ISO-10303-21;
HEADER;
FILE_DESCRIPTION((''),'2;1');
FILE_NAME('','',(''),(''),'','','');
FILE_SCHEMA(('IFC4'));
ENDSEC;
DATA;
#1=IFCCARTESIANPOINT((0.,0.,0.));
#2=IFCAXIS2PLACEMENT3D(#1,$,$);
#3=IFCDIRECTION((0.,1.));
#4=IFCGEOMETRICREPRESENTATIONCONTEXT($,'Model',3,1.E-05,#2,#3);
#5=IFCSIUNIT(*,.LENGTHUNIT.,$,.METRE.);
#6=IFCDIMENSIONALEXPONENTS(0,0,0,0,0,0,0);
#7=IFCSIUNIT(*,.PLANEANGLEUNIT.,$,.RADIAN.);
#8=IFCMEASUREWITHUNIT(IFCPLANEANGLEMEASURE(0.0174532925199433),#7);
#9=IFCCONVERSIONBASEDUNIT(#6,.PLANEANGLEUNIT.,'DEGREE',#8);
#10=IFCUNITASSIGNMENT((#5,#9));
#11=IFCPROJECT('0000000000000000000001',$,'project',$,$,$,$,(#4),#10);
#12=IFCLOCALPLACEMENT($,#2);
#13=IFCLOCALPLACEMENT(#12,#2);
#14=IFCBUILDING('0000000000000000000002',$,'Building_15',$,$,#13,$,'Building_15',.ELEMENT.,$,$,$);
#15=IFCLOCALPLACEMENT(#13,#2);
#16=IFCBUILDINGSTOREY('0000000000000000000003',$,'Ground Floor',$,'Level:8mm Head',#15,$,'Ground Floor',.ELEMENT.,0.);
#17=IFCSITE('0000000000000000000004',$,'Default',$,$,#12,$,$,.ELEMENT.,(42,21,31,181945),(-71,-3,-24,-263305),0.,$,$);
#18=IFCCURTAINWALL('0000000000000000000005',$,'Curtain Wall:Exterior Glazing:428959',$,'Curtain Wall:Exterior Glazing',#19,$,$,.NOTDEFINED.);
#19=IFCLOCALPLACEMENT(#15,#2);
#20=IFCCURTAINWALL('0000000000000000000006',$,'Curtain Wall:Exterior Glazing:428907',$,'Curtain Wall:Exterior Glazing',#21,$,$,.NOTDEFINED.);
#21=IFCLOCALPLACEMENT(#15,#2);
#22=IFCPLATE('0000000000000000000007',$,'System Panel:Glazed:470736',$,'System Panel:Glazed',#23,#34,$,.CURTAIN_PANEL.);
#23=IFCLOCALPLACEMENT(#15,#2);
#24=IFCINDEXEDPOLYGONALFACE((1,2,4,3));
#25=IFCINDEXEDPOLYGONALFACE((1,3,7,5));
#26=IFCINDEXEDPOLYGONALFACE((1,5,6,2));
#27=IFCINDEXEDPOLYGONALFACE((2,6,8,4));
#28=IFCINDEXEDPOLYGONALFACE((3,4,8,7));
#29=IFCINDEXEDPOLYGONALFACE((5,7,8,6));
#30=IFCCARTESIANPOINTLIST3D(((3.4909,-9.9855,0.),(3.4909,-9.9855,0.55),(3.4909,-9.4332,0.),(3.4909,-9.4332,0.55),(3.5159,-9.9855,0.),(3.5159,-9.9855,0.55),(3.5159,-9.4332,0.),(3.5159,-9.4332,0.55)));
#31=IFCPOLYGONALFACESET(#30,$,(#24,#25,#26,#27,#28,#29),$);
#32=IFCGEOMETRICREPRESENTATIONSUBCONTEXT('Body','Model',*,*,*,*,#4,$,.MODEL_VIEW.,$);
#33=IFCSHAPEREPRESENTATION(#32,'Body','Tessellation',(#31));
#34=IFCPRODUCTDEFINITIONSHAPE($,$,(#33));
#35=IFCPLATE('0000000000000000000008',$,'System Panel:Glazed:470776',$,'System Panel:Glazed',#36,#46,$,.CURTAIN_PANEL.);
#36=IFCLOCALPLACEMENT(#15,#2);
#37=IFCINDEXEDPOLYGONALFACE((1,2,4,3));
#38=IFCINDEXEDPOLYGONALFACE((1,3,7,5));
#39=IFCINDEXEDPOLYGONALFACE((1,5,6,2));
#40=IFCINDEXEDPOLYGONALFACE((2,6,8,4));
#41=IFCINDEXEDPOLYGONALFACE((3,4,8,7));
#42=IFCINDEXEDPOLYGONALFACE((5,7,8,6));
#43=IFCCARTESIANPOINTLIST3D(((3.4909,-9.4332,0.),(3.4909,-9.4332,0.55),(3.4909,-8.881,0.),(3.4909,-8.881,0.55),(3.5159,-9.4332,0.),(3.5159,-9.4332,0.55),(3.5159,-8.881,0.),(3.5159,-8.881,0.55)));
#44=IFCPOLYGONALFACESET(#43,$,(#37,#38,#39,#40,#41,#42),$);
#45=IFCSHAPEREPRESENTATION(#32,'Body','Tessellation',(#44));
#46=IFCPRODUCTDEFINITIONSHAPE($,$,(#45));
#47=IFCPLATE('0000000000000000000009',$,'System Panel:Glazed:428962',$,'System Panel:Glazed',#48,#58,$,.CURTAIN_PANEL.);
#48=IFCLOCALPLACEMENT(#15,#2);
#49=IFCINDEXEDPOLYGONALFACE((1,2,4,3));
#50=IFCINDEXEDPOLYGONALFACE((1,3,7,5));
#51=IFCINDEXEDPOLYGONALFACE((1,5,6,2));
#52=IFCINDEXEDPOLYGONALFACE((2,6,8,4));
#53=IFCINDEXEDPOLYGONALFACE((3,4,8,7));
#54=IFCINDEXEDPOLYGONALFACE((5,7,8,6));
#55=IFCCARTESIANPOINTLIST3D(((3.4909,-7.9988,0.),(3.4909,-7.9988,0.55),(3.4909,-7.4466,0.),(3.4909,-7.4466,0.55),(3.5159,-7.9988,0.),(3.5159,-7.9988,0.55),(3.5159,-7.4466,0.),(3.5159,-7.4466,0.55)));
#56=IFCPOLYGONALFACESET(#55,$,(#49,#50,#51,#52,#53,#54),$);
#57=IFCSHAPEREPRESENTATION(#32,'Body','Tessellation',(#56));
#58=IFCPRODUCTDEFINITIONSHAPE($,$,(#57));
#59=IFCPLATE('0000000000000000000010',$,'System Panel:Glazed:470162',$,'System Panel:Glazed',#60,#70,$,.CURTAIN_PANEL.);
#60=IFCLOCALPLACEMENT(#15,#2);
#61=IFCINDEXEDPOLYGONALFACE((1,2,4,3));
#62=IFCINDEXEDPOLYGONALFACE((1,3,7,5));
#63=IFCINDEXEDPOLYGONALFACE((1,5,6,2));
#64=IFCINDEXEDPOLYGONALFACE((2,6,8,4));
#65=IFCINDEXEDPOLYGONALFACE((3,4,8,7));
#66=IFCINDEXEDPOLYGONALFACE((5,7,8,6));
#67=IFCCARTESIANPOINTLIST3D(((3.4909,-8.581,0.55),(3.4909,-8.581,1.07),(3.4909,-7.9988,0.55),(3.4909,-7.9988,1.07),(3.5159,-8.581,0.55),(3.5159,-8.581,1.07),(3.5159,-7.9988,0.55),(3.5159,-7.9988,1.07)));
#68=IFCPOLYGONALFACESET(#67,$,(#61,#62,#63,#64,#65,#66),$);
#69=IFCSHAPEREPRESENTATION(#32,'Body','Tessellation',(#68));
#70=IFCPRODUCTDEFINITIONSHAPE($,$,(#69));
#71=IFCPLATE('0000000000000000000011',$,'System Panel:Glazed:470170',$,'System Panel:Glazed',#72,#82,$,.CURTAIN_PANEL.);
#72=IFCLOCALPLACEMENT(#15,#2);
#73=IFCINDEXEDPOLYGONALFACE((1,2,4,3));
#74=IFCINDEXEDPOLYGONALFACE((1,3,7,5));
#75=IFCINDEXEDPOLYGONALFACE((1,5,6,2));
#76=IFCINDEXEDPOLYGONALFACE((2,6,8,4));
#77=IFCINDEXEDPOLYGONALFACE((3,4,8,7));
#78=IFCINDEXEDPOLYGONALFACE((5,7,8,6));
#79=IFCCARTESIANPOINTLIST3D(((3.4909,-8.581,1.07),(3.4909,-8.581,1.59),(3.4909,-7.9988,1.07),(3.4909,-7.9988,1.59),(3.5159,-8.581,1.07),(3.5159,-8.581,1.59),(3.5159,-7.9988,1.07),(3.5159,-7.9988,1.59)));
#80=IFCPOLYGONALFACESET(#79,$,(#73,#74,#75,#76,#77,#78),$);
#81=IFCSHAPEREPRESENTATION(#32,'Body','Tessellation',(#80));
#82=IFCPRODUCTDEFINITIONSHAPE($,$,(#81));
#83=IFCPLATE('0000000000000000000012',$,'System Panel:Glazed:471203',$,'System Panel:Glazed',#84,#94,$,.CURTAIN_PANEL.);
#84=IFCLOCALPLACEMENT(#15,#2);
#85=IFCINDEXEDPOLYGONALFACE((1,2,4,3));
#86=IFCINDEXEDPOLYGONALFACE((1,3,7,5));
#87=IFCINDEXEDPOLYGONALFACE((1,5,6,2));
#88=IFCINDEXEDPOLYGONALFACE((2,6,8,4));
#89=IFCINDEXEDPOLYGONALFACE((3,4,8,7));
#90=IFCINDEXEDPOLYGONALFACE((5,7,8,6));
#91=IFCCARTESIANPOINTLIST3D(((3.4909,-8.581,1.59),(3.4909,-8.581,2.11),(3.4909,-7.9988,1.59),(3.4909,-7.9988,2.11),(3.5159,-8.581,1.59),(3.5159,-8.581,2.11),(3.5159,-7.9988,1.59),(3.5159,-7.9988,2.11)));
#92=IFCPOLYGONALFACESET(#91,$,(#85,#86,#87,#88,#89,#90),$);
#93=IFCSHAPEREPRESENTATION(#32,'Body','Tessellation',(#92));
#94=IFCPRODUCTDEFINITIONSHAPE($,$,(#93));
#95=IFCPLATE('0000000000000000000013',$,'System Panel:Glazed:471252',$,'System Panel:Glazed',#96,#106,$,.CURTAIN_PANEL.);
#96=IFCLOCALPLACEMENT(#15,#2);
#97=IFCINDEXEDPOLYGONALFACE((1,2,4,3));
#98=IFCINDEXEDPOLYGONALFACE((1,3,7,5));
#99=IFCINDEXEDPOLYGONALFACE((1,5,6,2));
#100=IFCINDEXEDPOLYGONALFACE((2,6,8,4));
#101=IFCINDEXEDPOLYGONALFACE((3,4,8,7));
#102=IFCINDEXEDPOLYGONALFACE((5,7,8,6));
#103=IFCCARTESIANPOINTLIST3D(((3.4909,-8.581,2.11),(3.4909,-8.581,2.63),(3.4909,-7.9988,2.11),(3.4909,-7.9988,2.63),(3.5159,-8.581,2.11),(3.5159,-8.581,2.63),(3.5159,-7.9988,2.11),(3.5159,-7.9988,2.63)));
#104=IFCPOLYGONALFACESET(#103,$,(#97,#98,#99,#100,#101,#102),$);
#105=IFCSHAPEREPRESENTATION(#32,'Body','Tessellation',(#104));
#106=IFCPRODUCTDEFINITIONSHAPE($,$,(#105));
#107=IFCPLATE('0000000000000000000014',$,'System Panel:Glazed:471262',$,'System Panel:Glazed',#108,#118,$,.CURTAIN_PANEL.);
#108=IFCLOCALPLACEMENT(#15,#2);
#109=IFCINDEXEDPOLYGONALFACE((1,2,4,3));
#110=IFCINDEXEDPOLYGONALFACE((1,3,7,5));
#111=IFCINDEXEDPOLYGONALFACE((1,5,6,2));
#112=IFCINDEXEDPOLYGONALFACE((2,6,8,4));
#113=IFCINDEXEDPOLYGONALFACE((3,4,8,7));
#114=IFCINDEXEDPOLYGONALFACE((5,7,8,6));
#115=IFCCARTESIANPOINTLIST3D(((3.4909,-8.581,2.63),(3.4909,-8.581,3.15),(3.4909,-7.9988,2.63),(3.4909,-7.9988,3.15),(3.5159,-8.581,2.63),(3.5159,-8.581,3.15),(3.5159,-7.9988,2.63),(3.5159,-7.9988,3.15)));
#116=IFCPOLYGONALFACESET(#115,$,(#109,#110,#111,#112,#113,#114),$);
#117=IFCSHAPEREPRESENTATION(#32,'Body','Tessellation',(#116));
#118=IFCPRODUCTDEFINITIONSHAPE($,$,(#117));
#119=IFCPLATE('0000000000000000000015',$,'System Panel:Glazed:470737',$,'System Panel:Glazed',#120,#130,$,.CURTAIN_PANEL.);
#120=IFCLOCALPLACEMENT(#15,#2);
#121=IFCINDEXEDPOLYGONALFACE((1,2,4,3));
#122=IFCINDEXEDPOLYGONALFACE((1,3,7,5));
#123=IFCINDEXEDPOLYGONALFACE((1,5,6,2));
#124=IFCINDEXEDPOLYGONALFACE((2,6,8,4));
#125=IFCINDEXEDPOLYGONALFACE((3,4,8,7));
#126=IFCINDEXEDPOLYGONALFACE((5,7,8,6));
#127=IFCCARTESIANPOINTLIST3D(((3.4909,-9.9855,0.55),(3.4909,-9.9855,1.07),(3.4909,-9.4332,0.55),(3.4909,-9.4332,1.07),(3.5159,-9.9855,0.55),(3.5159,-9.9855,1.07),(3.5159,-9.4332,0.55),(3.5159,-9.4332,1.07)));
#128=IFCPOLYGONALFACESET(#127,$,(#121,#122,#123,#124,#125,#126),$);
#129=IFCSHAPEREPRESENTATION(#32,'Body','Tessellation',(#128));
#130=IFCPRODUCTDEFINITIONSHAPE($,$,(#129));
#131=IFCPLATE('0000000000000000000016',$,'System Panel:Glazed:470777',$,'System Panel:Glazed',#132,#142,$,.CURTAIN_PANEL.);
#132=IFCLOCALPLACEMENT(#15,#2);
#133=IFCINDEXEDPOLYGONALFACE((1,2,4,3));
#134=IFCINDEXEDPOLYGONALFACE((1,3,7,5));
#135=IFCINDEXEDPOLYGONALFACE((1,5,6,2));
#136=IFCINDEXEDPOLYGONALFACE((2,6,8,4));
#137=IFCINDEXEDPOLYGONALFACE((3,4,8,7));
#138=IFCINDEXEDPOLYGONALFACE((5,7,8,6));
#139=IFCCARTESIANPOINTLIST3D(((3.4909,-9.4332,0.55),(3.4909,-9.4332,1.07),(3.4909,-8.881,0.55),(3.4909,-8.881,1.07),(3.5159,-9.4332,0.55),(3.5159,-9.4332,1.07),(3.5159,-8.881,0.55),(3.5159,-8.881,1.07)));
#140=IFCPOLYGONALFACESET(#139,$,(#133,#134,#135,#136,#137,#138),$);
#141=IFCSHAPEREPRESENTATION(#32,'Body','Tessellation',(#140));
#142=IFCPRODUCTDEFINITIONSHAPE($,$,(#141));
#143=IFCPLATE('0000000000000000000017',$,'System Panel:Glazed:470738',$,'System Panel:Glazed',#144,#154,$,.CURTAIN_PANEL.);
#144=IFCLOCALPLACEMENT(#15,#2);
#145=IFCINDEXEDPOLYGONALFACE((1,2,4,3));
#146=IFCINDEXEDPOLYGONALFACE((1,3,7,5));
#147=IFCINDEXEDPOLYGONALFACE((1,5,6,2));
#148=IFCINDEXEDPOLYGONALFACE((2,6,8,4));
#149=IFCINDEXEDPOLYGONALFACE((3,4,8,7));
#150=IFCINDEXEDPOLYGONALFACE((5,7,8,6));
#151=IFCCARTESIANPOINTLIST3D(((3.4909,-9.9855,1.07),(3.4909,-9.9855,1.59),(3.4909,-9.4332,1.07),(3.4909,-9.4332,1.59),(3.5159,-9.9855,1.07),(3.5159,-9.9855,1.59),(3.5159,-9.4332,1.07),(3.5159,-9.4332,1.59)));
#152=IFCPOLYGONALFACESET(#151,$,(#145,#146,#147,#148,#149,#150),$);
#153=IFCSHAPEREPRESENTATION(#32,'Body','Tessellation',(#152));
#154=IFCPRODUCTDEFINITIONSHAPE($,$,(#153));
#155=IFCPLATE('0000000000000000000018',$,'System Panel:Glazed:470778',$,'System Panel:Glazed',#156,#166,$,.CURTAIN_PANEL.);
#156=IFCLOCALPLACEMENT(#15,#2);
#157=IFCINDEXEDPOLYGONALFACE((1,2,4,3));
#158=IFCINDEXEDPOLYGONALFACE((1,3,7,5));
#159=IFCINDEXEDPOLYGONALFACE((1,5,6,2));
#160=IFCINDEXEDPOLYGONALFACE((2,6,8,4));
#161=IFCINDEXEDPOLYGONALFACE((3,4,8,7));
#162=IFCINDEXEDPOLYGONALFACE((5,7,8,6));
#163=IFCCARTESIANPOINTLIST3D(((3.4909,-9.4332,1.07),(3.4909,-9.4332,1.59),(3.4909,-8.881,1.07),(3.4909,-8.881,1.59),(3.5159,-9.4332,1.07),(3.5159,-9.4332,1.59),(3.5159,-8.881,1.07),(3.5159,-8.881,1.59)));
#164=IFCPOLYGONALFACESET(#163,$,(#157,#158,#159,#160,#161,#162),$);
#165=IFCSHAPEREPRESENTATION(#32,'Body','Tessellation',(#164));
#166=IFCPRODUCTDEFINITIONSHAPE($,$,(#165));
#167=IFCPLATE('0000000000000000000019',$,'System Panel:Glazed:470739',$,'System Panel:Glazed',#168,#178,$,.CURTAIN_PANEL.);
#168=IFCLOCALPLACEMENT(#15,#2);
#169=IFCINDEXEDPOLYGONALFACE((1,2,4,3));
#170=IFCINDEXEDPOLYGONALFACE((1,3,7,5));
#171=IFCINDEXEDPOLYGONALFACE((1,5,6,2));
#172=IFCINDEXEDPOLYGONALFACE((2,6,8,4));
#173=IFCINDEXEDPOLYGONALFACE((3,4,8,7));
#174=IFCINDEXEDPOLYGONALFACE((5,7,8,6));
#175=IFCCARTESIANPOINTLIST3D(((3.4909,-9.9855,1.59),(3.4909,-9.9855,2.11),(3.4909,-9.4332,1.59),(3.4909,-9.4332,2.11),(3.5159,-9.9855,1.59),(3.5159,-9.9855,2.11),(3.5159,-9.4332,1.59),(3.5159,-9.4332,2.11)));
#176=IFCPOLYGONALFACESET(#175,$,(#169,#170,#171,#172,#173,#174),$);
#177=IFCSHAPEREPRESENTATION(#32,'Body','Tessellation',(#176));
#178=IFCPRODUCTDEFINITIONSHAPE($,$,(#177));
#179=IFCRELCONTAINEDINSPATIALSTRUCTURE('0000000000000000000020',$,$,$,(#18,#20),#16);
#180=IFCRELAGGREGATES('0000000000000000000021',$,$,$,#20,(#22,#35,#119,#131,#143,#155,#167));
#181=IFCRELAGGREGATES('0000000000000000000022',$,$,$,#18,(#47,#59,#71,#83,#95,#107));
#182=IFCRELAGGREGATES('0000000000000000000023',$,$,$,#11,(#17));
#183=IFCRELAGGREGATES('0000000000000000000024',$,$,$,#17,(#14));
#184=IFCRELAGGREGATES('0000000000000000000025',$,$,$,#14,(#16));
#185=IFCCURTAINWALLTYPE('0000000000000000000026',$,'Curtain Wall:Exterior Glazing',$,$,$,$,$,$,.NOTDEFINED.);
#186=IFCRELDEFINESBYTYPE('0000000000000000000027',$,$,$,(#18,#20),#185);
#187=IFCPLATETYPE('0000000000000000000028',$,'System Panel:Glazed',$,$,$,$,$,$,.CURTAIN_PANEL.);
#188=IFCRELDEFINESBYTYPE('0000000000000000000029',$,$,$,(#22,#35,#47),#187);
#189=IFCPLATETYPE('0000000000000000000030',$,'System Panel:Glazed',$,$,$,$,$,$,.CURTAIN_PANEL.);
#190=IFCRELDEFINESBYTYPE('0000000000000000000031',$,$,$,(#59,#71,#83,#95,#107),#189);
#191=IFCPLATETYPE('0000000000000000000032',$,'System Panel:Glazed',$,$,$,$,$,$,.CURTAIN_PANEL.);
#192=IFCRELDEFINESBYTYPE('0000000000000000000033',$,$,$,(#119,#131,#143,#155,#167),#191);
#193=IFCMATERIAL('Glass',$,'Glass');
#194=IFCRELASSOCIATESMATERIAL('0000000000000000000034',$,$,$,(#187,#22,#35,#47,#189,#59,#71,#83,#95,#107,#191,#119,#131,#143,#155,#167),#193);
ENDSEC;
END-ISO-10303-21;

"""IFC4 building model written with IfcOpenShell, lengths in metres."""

from ifc_helpers import new_model, entity, si_unit, converted_unit, direction, frame, origin, place, context, subcontext, project, spatial, indexed_curve, outline, extrude, source, transform, mapped, material, type_object, type_shapes, element, aggregate, save


model = new_model("IFC4")

# Units and contexts
model_context = context("Model", 3, precision=1e-05, world=origin(), true_north=direction((0.0, 1.0)))
body_context = subcontext(model_context, "Body", "Model", "MODEL_VIEW")
ifc_project = project(units=[si_unit("LENGTHUNIT", "METRE"), converted_unit("PLANEANGLEUNIT", "DEGREE", entity("IfcPlaneAngleMeasure", 0.0174532925199433), si_unit("PLANEANGLEUNIT", "RADIAN"), dimensions=[0, 0, 0, 0, 0, 0, 0])], contexts=[model_context])

# Site, building, storey
site_placement = place(None, origin())
site = spatial("IfcSite", under=ifc_project, at=site_placement, Name="Default", CompositionType="ELEMENT", RefLatitude=(42, 21, 31, 181945), RefLongitude=(-71, -3, -24, -263305), RefElevation=0.0)
building_placement = place(site_placement, origin())
building = spatial("IfcBuilding", under=site, at=building_placement, Name="Building_15", LongName="Building_15", CompositionType="ELEMENT")
storey_placement = place(building_placement, origin())
storey = spatial("IfcBuildingStorey", under=building, at=storey_placement, Name="Ground Floor", ObjectType="Level:8mm Head", LongName="Ground Floor", CompositionType="ELEMENT", Elevation=0.0)

# Curtain wall
curtain_wall_type = type_object("IfcCurtainWallType", Name="Curtain Wall:Exterior Glazing", PredefinedType="NOTDEFINED")
curtain_wall_1_placement = place(storey_placement, origin())
curtain_wall_1 = element("IfcCurtainWall", 1, at=curtain_wall_1_placement, inside=storey, type_object=curtain_wall_type, Name="Curtain Wall:Exterior Glazing:428959", ObjectType="Curtain Wall:Exterior Glazing", PredefinedType="NOTDEFINED")

# Curtain wall
curtain_wall_2_placement = place(storey_placement, origin())
curtain_wall_2 = element("IfcCurtainWall", 2, at=curtain_wall_2_placement, inside=storey, type_object=curtain_wall_type, Name="Curtain Wall:Exterior Glazing:428907", ObjectType="Curtain Wall:Exterior Glazing", PredefinedType="NOTDEFINED")

# Plates
ifc_material_1 = material(Name="Glass", Category="Glass")
plate_type_1 = type_object("IfcPlateType", Name="System Panel:Glazed", PredefinedType="CURTAIN_PANEL", material=ifc_material_1)
shared_shape_1 = source(origin(), body_context, "Body", "SweptSolid", [
    extrude(outline(indexed_curve([(-0.0125, -0.2761), (0.0125, -0.2761), (0.0125, 0.2761), (-0.0125, 0.2761), (-0.0125, -0.2761)], self_intersect=False)), frame((0.0, 0.037, 0.0), z_axis=(0.0, 0.0, 1.0), x_axis=(0.0, 1.0, 0.0)), (0.0, 0.0, 1.0), 0.55),
])
type_shapes(plate_type_1, [shared_shape_1])
plate_1_placement = place(curtain_wall_2_placement, frame((3.5404, -9.7093, 0.0), z_axis=(0.0, 0.0, 1.0), x_axis=(0.0, 1.0, 0.0)))
plate_1 = element("IfcPlate", 3, at=plate_1_placement, type_object=plate_type_1, material=ifc_material_1, Name="System Panel:Glazed:470736", ObjectType="System Panel:Glazed", PredefinedType="CURTAIN_PANEL", context=body_context, shape_type="MappedRepresentation", body=[
    mapped(shared_shape_1, transform((0.0, 0.0, 0.0), scale=1.0)),
])
plate_2_placement = place(curtain_wall_2_placement, frame((3.5404, -9.1571, 0.0), z_axis=(0.0, 0.0, 1.0), x_axis=(0.0, 1.0, 0.0)))
plate_2 = element("IfcPlate", 4, at=plate_2_placement, type_object=plate_type_1, material=ifc_material_1, Name="System Panel:Glazed:470776", ObjectType="System Panel:Glazed", PredefinedType="CURTAIN_PANEL", context=body_context, shape_type="MappedRepresentation", body=[
    mapped(shared_shape_1, transform((0.0, 0.0, 0.0), scale=1.0)),
])
plate_3_placement = place(curtain_wall_1_placement, frame((3.5404, -7.7227, 0.0), z_axis=(0.0, 0.0, 1.0), x_axis=(0.0, 1.0, 0.0)))
plate_3 = element("IfcPlate", 5, at=plate_3_placement, type_object=plate_type_1, material=ifc_material_1, Name="System Panel:Glazed:428962", ObjectType="System Panel:Glazed", PredefinedType="CURTAIN_PANEL", context=body_context, shape_type="MappedRepresentation", body=[
    mapped(shared_shape_1, transform((0.0, 0.0, 0.0), scale=1.0)),
])
plate_type_2 = type_object("IfcPlateType", Name="System Panel:Glazed", PredefinedType="CURTAIN_PANEL", material=ifc_material_1)
shared_shape_2 = source(origin(), body_context, "Body", "SweptSolid", [
    extrude(outline(indexed_curve([(-0.0125, -0.2911), (0.0125, -0.2911), (0.0125, 0.2911), (-0.0125, 0.2911), (-0.0125, -0.2911)], self_intersect=False)), frame((0.0, 0.037, 0.0), z_axis=(0.0, 0.0, 1.0), x_axis=(0.0, 1.0, 0.0)), (0.0, 0.0, 1.0), 0.52),
])
type_shapes(plate_type_2, [shared_shape_2])
plate_4_placement = place(curtain_wall_1_placement, frame((3.5404, -8.2899, 0.55), z_axis=(0.0, 0.0, 1.0), x_axis=(0.0, 1.0, 0.0)))
plate_4 = element("IfcPlate", 6, at=plate_4_placement, type_object=plate_type_2, material=ifc_material_1, Name="System Panel:Glazed:470162", ObjectType="System Panel:Glazed", PredefinedType="CURTAIN_PANEL", context=body_context, shape_type="MappedRepresentation", body=[
    mapped(shared_shape_2, transform((0.0, 0.0, 0.0), scale=1.0)),
])
plate_5_placement = place(curtain_wall_1_placement, frame((3.5404, -8.2899, 1.07), z_axis=(0.0, 0.0, 1.0), x_axis=(0.0, 1.0, 0.0)))
plate_5 = element("IfcPlate", 7, at=plate_5_placement, type_object=plate_type_2, material=ifc_material_1, Name="System Panel:Glazed:470170", ObjectType="System Panel:Glazed", PredefinedType="CURTAIN_PANEL", context=body_context, shape_type="MappedRepresentation", body=[
    mapped(shared_shape_2, transform((0.0, 0.0, 0.0), scale=1.0)),
])
plate_6_placement = place(curtain_wall_1_placement, frame((3.5404, -8.2899, 1.59), z_axis=(0.0, 0.0, 1.0), x_axis=(0.0, 1.0, 0.0)))
plate_6 = element("IfcPlate", 8, at=plate_6_placement, type_object=plate_type_2, material=ifc_material_1, Name="System Panel:Glazed:471203", ObjectType="System Panel:Glazed", PredefinedType="CURTAIN_PANEL", context=body_context, shape_type="MappedRepresentation", body=[
    mapped(shared_shape_2, transform((0.0, 0.0, 0.0), scale=1.0)),
])
plate_7_placement = place(curtain_wall_1_placement, frame((3.5404, -8.2899, 2.11), z_axis=(0.0, 0.0, 1.0), x_axis=(0.0, 1.0, 0.0)))
plate_7 = element("IfcPlate", 9, at=plate_7_placement, type_object=plate_type_2, material=ifc_material_1, Name="System Panel:Glazed:471252", ObjectType="System Panel:Glazed", PredefinedType="CURTAIN_PANEL", context=body_context, shape_type="MappedRepresentation", body=[
    mapped(shared_shape_2, transform((0.0, 0.0, 0.0), scale=1.0)),
])
plate_8_placement = place(curtain_wall_1_placement, frame((3.5404, -8.2899, 2.63), z_axis=(0.0, 0.0, 1.0), x_axis=(0.0, 1.0, 0.0)))
plate_8 = element("IfcPlate", 10, at=plate_8_placement, type_object=plate_type_2, material=ifc_material_1, Name="System Panel:Glazed:471262", ObjectType="System Panel:Glazed", PredefinedType="CURTAIN_PANEL", context=body_context, shape_type="MappedRepresentation", body=[
    mapped(shared_shape_2, transform((0.0, 0.0, 0.0), scale=1.0)),
])
plate_type_3 = type_object("IfcPlateType", Name="System Panel:Glazed", PredefinedType="CURTAIN_PANEL", material=ifc_material_1)
shared_shape_3 = source(origin(), body_context, "Body", "SweptSolid", [
    extrude(outline(indexed_curve([(-0.0125, -0.2761), (0.0125, -0.2761), (0.0125, 0.2761), (-0.0125, 0.2761), (-0.0125, -0.2761)], self_intersect=False)), frame((0.0, 0.037, 0.0), z_axis=(0.0, 0.0, 1.0), x_axis=(0.0, 1.0, 0.0)), (0.0, 0.0, 1.0), 0.52),
])
type_shapes(plate_type_3, [shared_shape_3])
plate_9_placement = place(curtain_wall_2_placement, frame((3.5404, -9.7093, 0.55), z_axis=(0.0, 0.0, 1.0), x_axis=(0.0, 1.0, 0.0)))
plate_9 = element("IfcPlate", 11, at=plate_9_placement, type_object=plate_type_3, material=ifc_material_1, Name="System Panel:Glazed:470737", ObjectType="System Panel:Glazed", PredefinedType="CURTAIN_PANEL", context=body_context, shape_type="MappedRepresentation", body=[
    mapped(shared_shape_3, transform((0.0, 0.0, 0.0), scale=1.0)),
])
plate_10_placement = place(curtain_wall_2_placement, frame((3.5404, -9.1571, 0.55), z_axis=(0.0, 0.0, 1.0), x_axis=(0.0, 1.0, 0.0)))
plate_10 = element("IfcPlate", 12, at=plate_10_placement, type_object=plate_type_3, material=ifc_material_1, Name="System Panel:Glazed:470777", ObjectType="System Panel:Glazed", PredefinedType="CURTAIN_PANEL", context=body_context, shape_type="MappedRepresentation", body=[
    mapped(shared_shape_3, transform((0.0, 0.0, 0.0), scale=1.0)),
])
plate_11_placement = place(curtain_wall_2_placement, frame((3.5404, -9.7093, 1.07), z_axis=(0.0, 0.0, 1.0), x_axis=(0.0, 1.0, 0.0)))
plate_11 = element("IfcPlate", 13, at=plate_11_placement, type_object=plate_type_3, material=ifc_material_1, Name="System Panel:Glazed:470738", ObjectType="System Panel:Glazed", PredefinedType="CURTAIN_PANEL", context=body_context, shape_type="MappedRepresentation", body=[
    mapped(shared_shape_3, transform((0.0, 0.0, 0.0), scale=1.0)),
])
plate_12_placement = place(curtain_wall_2_placement, frame((3.5404, -9.1571, 1.07), z_axis=(0.0, 0.0, 1.0), x_axis=(0.0, 1.0, 0.0)))
plate_12 = element("IfcPlate", 14, at=plate_12_placement, type_object=plate_type_3, material=ifc_material_1, Name="System Panel:Glazed:470778", ObjectType="System Panel:Glazed", PredefinedType="CURTAIN_PANEL", context=body_context, shape_type="MappedRepresentation", body=[
    mapped(shared_shape_3, transform((0.0, 0.0, 0.0), scale=1.0)),
])
plate_13_placement = place(curtain_wall_2_placement, frame((3.5404, -9.7093, 1.59), z_axis=(0.0, 0.0, 1.0), x_axis=(0.0, 1.0, 0.0)))
plate_13 = element("IfcPlate", 15, at=plate_13_placement, type_object=plate_type_3, material=ifc_material_1, Name="System Panel:Glazed:470739", ObjectType="System Panel:Glazed", PredefinedType="CURTAIN_PANEL", context=body_context, shape_type="MappedRepresentation", body=[
    mapped(shared_shape_3, transform((0.0, 0.0, 0.0), scale=1.0)),
])
aggregate(curtain_wall_2, [plate_1, plate_2, plate_9, plate_10, plate_11, plate_12, plate_13])
aggregate(curtain_wall_1, [plate_3, plate_4, plate_5, plate_6, plate_7, plate_8])

save(model, "model.ifc")
